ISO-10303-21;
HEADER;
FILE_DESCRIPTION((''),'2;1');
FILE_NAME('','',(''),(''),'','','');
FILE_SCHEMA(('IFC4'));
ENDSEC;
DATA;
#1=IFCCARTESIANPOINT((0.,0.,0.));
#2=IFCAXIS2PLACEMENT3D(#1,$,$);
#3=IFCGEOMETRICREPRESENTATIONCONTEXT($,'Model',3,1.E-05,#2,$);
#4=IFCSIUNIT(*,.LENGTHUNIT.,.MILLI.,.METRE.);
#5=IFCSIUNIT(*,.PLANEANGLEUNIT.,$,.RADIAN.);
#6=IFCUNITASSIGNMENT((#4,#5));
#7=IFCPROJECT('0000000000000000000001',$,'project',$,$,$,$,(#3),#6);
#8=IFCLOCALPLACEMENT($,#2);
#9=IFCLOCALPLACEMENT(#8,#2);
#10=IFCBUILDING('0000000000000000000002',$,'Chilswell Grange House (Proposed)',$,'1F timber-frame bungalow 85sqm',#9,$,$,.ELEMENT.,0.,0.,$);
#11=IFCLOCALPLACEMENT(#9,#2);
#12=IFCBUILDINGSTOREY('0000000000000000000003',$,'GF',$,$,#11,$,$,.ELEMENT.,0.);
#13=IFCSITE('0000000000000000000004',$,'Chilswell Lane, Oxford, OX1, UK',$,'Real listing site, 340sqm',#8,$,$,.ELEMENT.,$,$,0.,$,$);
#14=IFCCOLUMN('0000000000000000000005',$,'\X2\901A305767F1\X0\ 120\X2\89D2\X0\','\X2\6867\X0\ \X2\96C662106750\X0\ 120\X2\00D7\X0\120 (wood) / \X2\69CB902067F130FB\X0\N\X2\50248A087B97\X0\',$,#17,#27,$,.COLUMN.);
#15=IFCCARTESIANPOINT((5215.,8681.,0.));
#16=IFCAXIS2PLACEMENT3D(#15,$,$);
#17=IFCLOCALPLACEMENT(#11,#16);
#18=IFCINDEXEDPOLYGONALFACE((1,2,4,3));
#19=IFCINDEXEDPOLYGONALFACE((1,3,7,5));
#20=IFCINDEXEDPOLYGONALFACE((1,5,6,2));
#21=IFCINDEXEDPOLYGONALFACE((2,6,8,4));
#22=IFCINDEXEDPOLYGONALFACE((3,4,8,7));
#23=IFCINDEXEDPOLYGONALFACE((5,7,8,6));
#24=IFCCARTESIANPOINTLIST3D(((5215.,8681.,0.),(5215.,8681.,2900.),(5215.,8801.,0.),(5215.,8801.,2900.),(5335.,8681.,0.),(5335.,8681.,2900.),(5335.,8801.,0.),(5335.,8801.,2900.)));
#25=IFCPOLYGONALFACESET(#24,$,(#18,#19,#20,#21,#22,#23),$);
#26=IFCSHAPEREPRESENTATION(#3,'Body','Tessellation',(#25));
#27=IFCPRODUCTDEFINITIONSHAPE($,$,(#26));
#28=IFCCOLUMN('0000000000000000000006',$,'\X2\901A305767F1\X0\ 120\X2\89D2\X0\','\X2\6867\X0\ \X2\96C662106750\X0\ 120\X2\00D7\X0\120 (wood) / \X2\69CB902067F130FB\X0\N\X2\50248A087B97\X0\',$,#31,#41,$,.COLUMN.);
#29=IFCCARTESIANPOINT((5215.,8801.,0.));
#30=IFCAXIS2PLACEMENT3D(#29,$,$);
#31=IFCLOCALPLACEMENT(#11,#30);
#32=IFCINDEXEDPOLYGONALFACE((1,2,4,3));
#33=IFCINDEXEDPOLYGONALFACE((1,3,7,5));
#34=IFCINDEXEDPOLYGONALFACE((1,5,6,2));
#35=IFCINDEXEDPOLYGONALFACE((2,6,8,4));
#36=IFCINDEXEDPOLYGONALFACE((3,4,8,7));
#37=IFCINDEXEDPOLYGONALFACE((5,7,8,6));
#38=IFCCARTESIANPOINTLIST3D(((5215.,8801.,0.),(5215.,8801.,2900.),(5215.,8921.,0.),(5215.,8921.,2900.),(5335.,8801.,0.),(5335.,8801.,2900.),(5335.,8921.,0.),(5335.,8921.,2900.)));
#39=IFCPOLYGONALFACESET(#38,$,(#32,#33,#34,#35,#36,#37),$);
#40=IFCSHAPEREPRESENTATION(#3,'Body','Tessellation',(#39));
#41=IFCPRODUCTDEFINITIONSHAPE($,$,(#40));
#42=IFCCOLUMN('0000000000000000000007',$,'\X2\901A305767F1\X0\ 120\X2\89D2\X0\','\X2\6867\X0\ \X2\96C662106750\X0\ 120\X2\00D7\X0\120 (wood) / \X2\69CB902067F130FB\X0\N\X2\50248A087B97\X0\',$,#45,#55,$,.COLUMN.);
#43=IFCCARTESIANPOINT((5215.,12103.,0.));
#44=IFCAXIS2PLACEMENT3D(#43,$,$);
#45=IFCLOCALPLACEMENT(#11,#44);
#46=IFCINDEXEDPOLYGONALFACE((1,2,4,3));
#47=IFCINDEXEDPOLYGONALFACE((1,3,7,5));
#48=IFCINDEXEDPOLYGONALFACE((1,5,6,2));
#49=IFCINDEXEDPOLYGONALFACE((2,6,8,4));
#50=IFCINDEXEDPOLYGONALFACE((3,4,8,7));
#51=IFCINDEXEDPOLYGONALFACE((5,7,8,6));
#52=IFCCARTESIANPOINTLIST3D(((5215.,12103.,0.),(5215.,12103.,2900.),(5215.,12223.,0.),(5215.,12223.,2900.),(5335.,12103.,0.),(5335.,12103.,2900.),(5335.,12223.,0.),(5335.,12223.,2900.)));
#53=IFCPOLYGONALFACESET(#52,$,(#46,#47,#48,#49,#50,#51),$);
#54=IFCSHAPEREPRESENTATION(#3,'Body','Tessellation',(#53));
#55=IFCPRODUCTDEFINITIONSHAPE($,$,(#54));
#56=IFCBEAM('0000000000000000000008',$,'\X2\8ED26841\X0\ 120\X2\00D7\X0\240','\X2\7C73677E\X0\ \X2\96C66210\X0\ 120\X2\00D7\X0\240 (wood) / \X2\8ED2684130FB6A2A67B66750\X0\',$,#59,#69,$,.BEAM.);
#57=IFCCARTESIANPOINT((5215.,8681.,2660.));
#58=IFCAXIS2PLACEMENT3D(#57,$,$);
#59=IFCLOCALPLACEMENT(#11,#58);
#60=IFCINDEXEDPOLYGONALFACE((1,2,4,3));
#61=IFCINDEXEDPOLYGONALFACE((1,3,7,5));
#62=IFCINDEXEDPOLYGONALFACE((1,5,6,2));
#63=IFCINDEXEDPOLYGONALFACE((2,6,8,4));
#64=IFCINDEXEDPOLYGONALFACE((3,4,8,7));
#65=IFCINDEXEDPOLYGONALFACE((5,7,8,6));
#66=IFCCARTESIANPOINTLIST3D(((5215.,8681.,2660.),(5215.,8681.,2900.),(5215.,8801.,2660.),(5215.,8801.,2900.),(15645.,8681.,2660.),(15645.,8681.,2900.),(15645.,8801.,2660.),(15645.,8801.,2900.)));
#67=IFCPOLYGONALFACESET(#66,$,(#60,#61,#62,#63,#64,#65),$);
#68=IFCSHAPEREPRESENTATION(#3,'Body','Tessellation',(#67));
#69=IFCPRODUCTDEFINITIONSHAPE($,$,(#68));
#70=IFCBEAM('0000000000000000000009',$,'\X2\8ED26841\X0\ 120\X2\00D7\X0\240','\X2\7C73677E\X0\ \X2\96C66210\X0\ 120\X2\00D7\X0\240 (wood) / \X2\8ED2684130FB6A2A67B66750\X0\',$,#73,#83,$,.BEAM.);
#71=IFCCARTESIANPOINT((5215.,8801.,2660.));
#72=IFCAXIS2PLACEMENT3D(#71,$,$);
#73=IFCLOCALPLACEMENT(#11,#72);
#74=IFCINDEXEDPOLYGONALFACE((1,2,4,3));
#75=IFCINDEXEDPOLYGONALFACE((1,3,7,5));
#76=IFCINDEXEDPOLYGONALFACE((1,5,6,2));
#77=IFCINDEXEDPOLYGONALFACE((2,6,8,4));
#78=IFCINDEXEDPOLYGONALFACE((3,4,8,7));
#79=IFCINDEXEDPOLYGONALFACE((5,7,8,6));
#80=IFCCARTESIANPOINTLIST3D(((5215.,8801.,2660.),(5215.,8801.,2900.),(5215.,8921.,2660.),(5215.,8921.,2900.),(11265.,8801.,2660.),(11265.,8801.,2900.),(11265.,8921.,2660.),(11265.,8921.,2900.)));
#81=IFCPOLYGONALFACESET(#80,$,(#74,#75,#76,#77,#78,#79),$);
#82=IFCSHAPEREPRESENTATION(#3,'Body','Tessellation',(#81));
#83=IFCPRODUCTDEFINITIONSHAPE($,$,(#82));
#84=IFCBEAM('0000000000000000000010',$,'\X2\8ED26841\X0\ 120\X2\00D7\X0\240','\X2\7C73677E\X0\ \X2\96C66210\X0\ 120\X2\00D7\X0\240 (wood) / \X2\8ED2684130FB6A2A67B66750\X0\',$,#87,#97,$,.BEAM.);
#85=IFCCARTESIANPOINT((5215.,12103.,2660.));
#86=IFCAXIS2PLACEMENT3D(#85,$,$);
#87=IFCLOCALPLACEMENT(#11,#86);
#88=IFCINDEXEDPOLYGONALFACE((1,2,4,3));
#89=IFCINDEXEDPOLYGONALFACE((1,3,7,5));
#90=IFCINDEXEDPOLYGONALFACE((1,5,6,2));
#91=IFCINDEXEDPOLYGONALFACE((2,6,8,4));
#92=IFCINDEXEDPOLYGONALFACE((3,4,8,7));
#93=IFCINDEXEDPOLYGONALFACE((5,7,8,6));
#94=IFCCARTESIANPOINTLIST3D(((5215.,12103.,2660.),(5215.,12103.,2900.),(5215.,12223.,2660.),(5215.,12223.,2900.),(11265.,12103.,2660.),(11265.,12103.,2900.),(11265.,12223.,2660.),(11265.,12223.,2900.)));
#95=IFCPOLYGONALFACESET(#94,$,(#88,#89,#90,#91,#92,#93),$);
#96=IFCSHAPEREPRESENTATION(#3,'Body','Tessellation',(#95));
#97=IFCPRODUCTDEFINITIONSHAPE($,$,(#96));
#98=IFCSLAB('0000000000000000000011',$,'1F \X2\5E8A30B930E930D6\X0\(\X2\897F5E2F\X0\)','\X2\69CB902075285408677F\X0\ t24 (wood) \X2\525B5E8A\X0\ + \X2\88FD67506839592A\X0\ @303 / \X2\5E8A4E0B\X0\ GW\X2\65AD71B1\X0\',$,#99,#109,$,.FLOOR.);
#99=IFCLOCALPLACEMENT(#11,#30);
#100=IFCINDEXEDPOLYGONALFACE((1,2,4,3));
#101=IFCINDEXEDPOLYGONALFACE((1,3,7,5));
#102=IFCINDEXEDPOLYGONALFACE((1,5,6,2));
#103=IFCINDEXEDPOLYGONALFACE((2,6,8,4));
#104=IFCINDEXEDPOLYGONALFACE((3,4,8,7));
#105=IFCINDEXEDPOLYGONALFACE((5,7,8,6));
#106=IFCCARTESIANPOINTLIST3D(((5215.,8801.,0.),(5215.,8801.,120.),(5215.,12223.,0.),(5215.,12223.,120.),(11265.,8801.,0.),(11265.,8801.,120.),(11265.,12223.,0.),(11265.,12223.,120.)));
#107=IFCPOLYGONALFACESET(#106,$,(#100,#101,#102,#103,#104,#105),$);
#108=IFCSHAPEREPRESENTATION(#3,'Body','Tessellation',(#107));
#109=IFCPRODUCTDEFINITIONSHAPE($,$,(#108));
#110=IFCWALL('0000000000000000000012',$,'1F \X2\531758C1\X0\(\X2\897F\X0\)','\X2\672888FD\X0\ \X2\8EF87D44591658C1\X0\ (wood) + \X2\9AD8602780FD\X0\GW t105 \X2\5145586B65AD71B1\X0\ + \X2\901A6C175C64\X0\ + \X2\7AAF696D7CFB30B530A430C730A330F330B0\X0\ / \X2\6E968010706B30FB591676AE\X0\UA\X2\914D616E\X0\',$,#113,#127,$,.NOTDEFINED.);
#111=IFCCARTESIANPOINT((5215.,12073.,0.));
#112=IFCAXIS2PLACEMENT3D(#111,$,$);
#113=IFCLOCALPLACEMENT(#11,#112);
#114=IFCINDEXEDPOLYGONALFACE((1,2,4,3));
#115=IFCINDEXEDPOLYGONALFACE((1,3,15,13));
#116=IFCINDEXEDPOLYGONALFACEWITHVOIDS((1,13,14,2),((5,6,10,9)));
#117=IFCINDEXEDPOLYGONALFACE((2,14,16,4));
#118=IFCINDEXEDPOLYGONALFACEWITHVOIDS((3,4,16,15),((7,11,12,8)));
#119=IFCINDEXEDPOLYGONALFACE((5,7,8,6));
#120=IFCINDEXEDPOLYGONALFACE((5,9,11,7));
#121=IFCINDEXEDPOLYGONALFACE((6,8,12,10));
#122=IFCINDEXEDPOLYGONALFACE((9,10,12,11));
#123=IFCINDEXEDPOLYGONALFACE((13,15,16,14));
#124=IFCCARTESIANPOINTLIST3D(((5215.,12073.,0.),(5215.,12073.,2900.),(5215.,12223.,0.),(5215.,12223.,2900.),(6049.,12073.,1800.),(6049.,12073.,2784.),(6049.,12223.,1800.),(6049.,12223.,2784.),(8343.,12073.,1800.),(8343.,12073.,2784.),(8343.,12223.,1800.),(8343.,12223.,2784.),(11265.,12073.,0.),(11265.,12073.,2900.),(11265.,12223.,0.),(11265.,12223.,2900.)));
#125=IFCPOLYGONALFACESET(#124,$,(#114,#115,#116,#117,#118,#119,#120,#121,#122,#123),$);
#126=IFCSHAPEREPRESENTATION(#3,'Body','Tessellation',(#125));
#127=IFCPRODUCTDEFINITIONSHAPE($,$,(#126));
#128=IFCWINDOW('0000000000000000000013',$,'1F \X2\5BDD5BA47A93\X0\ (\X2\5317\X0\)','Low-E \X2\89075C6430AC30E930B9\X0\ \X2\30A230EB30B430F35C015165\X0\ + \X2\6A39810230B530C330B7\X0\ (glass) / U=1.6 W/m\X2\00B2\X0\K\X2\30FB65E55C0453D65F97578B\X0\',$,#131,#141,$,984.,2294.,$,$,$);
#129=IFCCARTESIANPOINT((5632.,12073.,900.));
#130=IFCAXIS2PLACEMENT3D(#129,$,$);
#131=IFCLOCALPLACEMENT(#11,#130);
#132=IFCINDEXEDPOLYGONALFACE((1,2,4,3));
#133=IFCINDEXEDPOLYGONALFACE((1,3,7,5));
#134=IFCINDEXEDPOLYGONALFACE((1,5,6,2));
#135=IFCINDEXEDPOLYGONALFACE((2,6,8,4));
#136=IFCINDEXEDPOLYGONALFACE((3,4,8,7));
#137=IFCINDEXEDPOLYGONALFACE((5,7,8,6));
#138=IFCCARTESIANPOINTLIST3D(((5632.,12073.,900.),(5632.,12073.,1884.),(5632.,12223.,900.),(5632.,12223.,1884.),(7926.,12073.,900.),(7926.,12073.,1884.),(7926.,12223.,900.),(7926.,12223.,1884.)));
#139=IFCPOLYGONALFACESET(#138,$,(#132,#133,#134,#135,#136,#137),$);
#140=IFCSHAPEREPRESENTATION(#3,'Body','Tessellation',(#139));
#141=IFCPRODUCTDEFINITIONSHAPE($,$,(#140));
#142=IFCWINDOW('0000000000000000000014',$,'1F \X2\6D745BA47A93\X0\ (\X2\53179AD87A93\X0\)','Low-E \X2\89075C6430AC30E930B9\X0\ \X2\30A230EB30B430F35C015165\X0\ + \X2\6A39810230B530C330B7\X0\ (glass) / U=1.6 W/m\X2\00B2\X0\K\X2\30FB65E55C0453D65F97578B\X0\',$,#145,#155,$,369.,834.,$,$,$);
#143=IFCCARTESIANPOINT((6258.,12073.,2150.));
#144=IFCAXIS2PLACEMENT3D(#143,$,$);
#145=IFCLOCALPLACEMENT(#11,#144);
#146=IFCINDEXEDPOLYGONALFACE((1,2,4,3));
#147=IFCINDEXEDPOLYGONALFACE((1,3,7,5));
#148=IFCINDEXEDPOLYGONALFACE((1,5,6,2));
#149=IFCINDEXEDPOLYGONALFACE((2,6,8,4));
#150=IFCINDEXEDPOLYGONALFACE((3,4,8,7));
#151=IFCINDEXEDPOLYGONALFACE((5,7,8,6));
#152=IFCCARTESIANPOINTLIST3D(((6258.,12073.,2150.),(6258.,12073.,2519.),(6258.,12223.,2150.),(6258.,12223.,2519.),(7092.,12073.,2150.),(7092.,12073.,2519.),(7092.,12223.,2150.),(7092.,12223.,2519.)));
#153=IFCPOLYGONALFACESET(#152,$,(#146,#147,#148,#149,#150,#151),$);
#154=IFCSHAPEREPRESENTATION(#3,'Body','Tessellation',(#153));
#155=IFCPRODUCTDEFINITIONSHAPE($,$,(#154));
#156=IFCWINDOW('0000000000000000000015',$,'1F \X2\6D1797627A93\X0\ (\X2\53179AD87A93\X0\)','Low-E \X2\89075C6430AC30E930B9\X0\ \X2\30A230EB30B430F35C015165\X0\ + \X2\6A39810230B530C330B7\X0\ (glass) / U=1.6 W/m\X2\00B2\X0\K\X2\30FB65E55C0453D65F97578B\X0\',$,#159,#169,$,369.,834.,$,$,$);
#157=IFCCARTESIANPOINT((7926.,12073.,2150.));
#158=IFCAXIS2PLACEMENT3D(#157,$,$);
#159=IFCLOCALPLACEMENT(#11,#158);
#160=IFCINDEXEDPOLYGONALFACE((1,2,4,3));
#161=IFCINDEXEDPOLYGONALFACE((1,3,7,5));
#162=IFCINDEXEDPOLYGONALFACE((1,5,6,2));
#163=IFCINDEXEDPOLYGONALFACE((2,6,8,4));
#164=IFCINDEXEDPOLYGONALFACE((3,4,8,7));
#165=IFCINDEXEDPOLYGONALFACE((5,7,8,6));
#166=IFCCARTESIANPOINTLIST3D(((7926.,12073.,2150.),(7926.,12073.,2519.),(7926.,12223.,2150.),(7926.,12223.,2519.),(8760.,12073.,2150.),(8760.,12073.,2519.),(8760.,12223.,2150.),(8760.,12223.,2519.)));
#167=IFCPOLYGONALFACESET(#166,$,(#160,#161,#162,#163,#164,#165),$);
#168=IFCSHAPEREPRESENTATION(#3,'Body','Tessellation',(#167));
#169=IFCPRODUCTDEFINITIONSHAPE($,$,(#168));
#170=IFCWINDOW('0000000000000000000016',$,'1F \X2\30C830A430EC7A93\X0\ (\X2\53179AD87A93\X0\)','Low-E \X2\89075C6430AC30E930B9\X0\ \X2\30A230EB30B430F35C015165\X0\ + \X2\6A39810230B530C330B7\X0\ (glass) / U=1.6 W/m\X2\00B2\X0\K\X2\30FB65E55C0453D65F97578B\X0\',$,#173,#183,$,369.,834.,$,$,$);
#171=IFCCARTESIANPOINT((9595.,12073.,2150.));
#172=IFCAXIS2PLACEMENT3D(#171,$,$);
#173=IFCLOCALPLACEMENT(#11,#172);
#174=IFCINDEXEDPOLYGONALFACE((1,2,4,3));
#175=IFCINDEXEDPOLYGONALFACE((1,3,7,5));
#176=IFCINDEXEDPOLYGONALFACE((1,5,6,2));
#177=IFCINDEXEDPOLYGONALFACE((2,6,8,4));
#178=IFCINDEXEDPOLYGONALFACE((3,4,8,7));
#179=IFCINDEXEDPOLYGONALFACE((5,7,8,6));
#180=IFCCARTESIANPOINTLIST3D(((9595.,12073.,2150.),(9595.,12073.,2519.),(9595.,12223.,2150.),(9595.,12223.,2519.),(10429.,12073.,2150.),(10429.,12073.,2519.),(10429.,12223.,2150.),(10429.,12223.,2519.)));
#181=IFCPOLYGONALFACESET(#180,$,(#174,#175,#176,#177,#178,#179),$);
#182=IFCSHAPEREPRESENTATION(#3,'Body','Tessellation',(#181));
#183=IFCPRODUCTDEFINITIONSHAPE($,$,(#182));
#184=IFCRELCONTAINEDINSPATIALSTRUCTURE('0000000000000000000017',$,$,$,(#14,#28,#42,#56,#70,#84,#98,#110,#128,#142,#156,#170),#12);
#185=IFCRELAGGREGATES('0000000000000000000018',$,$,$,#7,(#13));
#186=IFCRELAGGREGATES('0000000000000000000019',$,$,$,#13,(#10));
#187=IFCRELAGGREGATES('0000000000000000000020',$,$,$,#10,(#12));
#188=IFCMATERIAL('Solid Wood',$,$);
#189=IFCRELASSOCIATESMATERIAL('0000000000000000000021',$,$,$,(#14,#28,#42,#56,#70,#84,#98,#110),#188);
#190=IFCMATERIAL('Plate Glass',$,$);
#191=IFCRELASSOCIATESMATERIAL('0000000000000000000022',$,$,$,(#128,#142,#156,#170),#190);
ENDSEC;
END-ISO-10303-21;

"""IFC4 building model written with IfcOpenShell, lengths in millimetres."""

from ifc_helpers import new_model, si_unit, frame, frame_2d, origin, place, context, project, spatial, rectangle, extrude, material, element, fill, save


model = new_model("IFC4")

# Units and contexts
model_context = context("Model", 3, precision=1e-05, world=origin())
ifc_project = project(units=[si_unit("LENGTHUNIT", "METRE", prefix="MILLI"), si_unit("PLANEANGLEUNIT", "RADIAN")], contexts=[model_context])

# Site, building, storey
site_placement = place(None, origin())
site = spatial("IfcSite", under=ifc_project, at=site_placement, Name="Chilswell Lane, Oxford, OX1, UK", ObjectType="Real listing site, 340sqm", CompositionType="ELEMENT", RefElevation=0.0)
building_placement = place(site_placement, origin())
building = spatial("IfcBuilding", under=site, at=building_placement, Name="Chilswell Grange House (Proposed)", ObjectType="1F timber-frame bungalow 85sqm", CompositionType="ELEMENT", ElevationOfRefHeight=0.0, ElevationOfTerrain=0.0)
storey_placement = place(building_placement, origin())
storey = spatial("IfcBuildingStorey", under=building, at=storey_placement, Name="GF", CompositionType="ELEMENT", Elevation=0.0)

# Columns
ifc_material_1 = material(Name="Solid Wood")
column_1_placement = place(storey_placement, frame((5215.0, 8681.0, 0.0)))
element("IfcColumn", 1, at=column_1_placement, inside=storey, material=ifc_material_1, Name="通し柱 120角", Description="桧 集成材 120×120 (wood) / 構造柱・N値計算", PredefinedType="COLUMN", context=model_context, shape_type="SweptSolid", body=[
    extrude(rectangle(XDim=120.0, YDim=120.0, at=frame_2d((60.0, 60.0))), frame((5215.0, 8681.0, 0.0)), (0.0, 0.0, 1.0), 2900.0),
])
column_2_placement = place(storey_placement, frame((5215.0, 8801.0, 0.0)))
element("IfcColumn", 2, at=column_2_placement, inside=storey, material=ifc_material_1, Name="通し柱 120角", Description="桧 集成材 120×120 (wood) / 構造柱・N値計算", PredefinedType="COLUMN", context=model_context, shape_type="SweptSolid", body=[
    extrude(rectangle(XDim=120.0, YDim=120.0, at=frame_2d((60.0, 60.0))), frame((5215.0, 8801.0, 0.0)), (0.0, 0.0, 1.0), 2900.0),
])
column_3_placement = place(storey_placement, frame((5215.0, 12103.0, 0.0)))
element("IfcColumn", 3, at=column_3_placement, inside=storey, material=ifc_material_1, Name="通し柱 120角", Description="桧 集成材 120×120 (wood) / 構造柱・N値計算", PredefinedType="COLUMN", context=model_context, shape_type="SweptSolid", body=[
    extrude(rectangle(XDim=120.0, YDim=120.0, at=frame_2d((60.0, 60.0))), frame((5215.0, 12103.0, 0.0)), (0.0, 0.0, 1.0), 2900.0),
])

# Beams
beam_1_placement = place(storey_placement, frame((5215.0, 8681.0, 2660.0)))
element("IfcBeam", 4, at=beam_1_placement, inside=storey, material=ifc_material_1, Name="軒桁 120×240", Description="米松 集成 120×240 (wood) / 軒桁・横架材", PredefinedType="BEAM", context=model_context, shape_type="SweptSolid", body=[
    extrude(rectangle(XDim=10430.0, YDim=120.0, at=frame_2d((5215.0, 60.0))), frame((5215.0, 8681.0, 2660.0)), (0.0, 0.0, 1.0), 240.0),
])
beam_2_placement = place(storey_placement, frame((5215.0, 8801.0, 2660.0)))
element("IfcBeam", 5, at=beam_2_placement, inside=storey, material=ifc_material_1, Name="軒桁 120×240", Description="米松 集成 120×240 (wood) / 軒桁・横架材", PredefinedType="BEAM", context=model_context, shape_type="SweptSolid", body=[
    extrude(rectangle(XDim=6050.0, YDim=120.0, at=frame_2d((3025.0, 60.0))), frame((5215.0, 8801.0, 2660.0)), (0.0, 0.0, 1.0), 240.0),
])
beam_3_placement = place(storey_placement, frame((5215.0, 12103.0, 2660.0)))
element("IfcBeam", 6, at=beam_3_placement, inside=storey, material=ifc_material_1, Name="軒桁 120×240", Description="米松 集成 120×240 (wood) / 軒桁・横架材", PredefinedType="BEAM", context=model_context, shape_type="SweptSolid", body=[
    extrude(rectangle(XDim=6050.0, YDim=120.0, at=frame_2d((3025.0, 60.0))), frame((5215.0, 12103.0, 2660.0)), (0.0, 0.0, 1.0), 240.0),
])

# Slab
slab_placement = place(storey_placement, frame((5215.0, 8801.0, 0.0)))
element("IfcSlab", 7, at=slab_placement, inside=storey, material=ifc_material_1, Name="1F 床スラブ(西帯)", Description="構造用合板 t24 (wood) 剛床 + 製材根太 @303 / 床下 GW断熱", PredefinedType="FLOOR", context=model_context, shape_type="SweptSolid", body=[
    extrude(rectangle(XDim=6050.0, YDim=3422.0, at=frame_2d((3025.0, 1711.0))), frame((5215.0, 8801.0, 0.0)), (0.0, 0.0, 1.0), 120.0),
])

# Wall, openings, windows
wall_1_placement = place(storey_placement, frame((5215.0, 12073.0, 0.0)))
wall_1 = element("IfcWall", 8, at=wall_1_placement, inside=storey, material=ifc_material_1, Name="1F 北壁(西)", Description="木製 軸組外壁 (wood) + 高性能GW t105 充填断熱 + 通気層 + 窯業系サイディング / 準耐火・外皮UA配慮", PredefinedType="NOTDEFINED", context=model_context, shape_type="SweptSolid", body=[
    extrude(rectangle(XDim=6050.0, YDim=150.0, at=frame_2d((3025.0, 75.0))), frame((5215.0, 12073.0, 0.0)), (0.0, 0.0, 1.0), 2900.0),
])
opening_1_placement = place(storey_placement, frame((5632.0, 12073.0, 900.0)))
opening_1 = element("IfcOpeningElement", 9, at=opening_1_placement, cuts=wall_1, PredefinedType="NOTDEFINED", context=model_context, shape_type="SweptSolid", body=[
    extrude(rectangle(XDim=2294.0, YDim=150.0, at=frame_2d((1147.0, 75.0))), frame((5632.0, 12073.0, 900.0)), (0.0, 0.0, 1.0), 984.0),
])
opening_2_placement = place(storey_placement, frame((6258.0, 12073.0, 2150.0)))
opening_2 = element("IfcOpeningElement", 10, at=opening_2_placement, cuts=wall_1, PredefinedType="NOTDEFINED", context=model_context, shape_type="SweptSolid", body=[
    extrude(rectangle(XDim=834.0, YDim=150.0, at=frame_2d((417.0, 75.0))), frame((6258.0, 12073.0, 2150.0)), (0.0, 0.0, 1.0), 369.0),
])
opening_3_placement = place(storey_placement, frame((7926.0, 12073.0, 2150.0)))
opening_3 = element("IfcOpeningElement", 11, at=opening_3_placement, cuts=wall_1, PredefinedType="NOTDEFINED", context=model_context, shape_type="SweptSolid", body=[
    extrude(rectangle(XDim=834.0, YDim=150.0, at=frame_2d((417.0, 75.0))), frame((7926.0, 12073.0, 2150.0)), (0.0, 0.0, 1.0), 369.0),
])
opening_4_placement = place(storey_placement, frame((9595.0, 12073.0, 2150.0)))
opening_4 = element("IfcOpeningElement", 12, at=opening_4_placement, cuts=wall_1, PredefinedType="NOTDEFINED", context=model_context, shape_type="SweptSolid", body=[
    extrude(rectangle(XDim=834.0, YDim=150.0, at=frame_2d((417.0, 75.0))), frame((9595.0, 12073.0, 2150.0)), (0.0, 0.0, 1.0), 369.0),
])
ifc_material_2 = material(Name="Plate Glass")
window_1_placement = place(storey_placement, frame((5632.0, 12073.0, 900.0)))
window_1 = element("IfcWindow", 13, at=window_1_placement, inside=storey, material=ifc_material_2, Name="1F 寝室窓 (北)", Description="Low-E 複層ガラス アルゴン封入 + 樹脂サッシ (glass) / U=1.6 W/m²K・日射取得型", OverallHeight=984.0, OverallWidth=2294.0, context=model_context, shape_type="SweptSolid", body=[
    extrude(rectangle(XDim=2294.0, YDim=150.0, at=frame_2d((1147.0, 75.0))), frame((5632.0, 12073.0, 900.0)), (0.0, 0.0, 1.0), 984.0),
])
fill(opening_1, window_1)
window_2_placement = place(storey_placement, frame((6258.0, 12073.0, 2150.0)))
window_2 = element("IfcWindow", 14, at=window_2_placement, inside=storey, material=ifc_material_2, Name="1F 浴室窓 (北高窓)", Description="Low-E 複層ガラス アルゴン封入 + 樹脂サッシ (glass) / U=1.6 W/m²K・日射取得型", OverallHeight=369.0, OverallWidth=834.0, context=model_context, shape_type="SweptSolid", body=[
    extrude(rectangle(XDim=834.0, YDim=150.0, at=frame_2d((417.0, 75.0))), frame((6258.0, 12073.0, 2150.0)), (0.0, 0.0, 1.0), 369.0),
])
fill(opening_2, window_2)
window_3_placement = place(storey_placement, frame((7926.0, 12073.0, 2150.0)))
window_3 = element("IfcWindow", 15, at=window_3_placement, inside=storey, material=ifc_material_2, Name="1F 洗面窓 (北高窓)", Description="Low-E 複層ガラス アルゴン封入 + 樹脂サッシ (glass) / U=1.6 W/m²K・日射取得型", OverallHeight=369.0, OverallWidth=834.0, context=model_context, shape_type="SweptSolid", body=[
    extrude(rectangle(XDim=834.0, YDim=150.0, at=frame_2d((417.0, 75.0))), frame((7926.0, 12073.0, 2150.0)), (0.0, 0.0, 1.0), 369.0),
])
fill(opening_3, window_3)
window_4_placement = place(storey_placement, frame((9595.0, 12073.0, 2150.0)))
window_4 = element("IfcWindow", 16, at=window_4_placement, inside=storey, material=ifc_material_2, Name="1F トイレ窓 (北高窓)", Description="Low-E 複層ガラス アルゴン封入 + 樹脂サッシ (glass) / U=1.6 W/m²K・日射取得型", OverallHeight=369.0, OverallWidth=834.0, context=model_context, shape_type="SweptSolid", body=[
    extrude(rectangle(XDim=834.0, YDim=150.0, at=frame_2d((417.0, 75.0))), frame((9595.0, 12073.0, 2150.0)), (0.0, 0.0, 1.0), 369.0),
])
fill(opening_4, window_4)

save(model, "model.ifc")
